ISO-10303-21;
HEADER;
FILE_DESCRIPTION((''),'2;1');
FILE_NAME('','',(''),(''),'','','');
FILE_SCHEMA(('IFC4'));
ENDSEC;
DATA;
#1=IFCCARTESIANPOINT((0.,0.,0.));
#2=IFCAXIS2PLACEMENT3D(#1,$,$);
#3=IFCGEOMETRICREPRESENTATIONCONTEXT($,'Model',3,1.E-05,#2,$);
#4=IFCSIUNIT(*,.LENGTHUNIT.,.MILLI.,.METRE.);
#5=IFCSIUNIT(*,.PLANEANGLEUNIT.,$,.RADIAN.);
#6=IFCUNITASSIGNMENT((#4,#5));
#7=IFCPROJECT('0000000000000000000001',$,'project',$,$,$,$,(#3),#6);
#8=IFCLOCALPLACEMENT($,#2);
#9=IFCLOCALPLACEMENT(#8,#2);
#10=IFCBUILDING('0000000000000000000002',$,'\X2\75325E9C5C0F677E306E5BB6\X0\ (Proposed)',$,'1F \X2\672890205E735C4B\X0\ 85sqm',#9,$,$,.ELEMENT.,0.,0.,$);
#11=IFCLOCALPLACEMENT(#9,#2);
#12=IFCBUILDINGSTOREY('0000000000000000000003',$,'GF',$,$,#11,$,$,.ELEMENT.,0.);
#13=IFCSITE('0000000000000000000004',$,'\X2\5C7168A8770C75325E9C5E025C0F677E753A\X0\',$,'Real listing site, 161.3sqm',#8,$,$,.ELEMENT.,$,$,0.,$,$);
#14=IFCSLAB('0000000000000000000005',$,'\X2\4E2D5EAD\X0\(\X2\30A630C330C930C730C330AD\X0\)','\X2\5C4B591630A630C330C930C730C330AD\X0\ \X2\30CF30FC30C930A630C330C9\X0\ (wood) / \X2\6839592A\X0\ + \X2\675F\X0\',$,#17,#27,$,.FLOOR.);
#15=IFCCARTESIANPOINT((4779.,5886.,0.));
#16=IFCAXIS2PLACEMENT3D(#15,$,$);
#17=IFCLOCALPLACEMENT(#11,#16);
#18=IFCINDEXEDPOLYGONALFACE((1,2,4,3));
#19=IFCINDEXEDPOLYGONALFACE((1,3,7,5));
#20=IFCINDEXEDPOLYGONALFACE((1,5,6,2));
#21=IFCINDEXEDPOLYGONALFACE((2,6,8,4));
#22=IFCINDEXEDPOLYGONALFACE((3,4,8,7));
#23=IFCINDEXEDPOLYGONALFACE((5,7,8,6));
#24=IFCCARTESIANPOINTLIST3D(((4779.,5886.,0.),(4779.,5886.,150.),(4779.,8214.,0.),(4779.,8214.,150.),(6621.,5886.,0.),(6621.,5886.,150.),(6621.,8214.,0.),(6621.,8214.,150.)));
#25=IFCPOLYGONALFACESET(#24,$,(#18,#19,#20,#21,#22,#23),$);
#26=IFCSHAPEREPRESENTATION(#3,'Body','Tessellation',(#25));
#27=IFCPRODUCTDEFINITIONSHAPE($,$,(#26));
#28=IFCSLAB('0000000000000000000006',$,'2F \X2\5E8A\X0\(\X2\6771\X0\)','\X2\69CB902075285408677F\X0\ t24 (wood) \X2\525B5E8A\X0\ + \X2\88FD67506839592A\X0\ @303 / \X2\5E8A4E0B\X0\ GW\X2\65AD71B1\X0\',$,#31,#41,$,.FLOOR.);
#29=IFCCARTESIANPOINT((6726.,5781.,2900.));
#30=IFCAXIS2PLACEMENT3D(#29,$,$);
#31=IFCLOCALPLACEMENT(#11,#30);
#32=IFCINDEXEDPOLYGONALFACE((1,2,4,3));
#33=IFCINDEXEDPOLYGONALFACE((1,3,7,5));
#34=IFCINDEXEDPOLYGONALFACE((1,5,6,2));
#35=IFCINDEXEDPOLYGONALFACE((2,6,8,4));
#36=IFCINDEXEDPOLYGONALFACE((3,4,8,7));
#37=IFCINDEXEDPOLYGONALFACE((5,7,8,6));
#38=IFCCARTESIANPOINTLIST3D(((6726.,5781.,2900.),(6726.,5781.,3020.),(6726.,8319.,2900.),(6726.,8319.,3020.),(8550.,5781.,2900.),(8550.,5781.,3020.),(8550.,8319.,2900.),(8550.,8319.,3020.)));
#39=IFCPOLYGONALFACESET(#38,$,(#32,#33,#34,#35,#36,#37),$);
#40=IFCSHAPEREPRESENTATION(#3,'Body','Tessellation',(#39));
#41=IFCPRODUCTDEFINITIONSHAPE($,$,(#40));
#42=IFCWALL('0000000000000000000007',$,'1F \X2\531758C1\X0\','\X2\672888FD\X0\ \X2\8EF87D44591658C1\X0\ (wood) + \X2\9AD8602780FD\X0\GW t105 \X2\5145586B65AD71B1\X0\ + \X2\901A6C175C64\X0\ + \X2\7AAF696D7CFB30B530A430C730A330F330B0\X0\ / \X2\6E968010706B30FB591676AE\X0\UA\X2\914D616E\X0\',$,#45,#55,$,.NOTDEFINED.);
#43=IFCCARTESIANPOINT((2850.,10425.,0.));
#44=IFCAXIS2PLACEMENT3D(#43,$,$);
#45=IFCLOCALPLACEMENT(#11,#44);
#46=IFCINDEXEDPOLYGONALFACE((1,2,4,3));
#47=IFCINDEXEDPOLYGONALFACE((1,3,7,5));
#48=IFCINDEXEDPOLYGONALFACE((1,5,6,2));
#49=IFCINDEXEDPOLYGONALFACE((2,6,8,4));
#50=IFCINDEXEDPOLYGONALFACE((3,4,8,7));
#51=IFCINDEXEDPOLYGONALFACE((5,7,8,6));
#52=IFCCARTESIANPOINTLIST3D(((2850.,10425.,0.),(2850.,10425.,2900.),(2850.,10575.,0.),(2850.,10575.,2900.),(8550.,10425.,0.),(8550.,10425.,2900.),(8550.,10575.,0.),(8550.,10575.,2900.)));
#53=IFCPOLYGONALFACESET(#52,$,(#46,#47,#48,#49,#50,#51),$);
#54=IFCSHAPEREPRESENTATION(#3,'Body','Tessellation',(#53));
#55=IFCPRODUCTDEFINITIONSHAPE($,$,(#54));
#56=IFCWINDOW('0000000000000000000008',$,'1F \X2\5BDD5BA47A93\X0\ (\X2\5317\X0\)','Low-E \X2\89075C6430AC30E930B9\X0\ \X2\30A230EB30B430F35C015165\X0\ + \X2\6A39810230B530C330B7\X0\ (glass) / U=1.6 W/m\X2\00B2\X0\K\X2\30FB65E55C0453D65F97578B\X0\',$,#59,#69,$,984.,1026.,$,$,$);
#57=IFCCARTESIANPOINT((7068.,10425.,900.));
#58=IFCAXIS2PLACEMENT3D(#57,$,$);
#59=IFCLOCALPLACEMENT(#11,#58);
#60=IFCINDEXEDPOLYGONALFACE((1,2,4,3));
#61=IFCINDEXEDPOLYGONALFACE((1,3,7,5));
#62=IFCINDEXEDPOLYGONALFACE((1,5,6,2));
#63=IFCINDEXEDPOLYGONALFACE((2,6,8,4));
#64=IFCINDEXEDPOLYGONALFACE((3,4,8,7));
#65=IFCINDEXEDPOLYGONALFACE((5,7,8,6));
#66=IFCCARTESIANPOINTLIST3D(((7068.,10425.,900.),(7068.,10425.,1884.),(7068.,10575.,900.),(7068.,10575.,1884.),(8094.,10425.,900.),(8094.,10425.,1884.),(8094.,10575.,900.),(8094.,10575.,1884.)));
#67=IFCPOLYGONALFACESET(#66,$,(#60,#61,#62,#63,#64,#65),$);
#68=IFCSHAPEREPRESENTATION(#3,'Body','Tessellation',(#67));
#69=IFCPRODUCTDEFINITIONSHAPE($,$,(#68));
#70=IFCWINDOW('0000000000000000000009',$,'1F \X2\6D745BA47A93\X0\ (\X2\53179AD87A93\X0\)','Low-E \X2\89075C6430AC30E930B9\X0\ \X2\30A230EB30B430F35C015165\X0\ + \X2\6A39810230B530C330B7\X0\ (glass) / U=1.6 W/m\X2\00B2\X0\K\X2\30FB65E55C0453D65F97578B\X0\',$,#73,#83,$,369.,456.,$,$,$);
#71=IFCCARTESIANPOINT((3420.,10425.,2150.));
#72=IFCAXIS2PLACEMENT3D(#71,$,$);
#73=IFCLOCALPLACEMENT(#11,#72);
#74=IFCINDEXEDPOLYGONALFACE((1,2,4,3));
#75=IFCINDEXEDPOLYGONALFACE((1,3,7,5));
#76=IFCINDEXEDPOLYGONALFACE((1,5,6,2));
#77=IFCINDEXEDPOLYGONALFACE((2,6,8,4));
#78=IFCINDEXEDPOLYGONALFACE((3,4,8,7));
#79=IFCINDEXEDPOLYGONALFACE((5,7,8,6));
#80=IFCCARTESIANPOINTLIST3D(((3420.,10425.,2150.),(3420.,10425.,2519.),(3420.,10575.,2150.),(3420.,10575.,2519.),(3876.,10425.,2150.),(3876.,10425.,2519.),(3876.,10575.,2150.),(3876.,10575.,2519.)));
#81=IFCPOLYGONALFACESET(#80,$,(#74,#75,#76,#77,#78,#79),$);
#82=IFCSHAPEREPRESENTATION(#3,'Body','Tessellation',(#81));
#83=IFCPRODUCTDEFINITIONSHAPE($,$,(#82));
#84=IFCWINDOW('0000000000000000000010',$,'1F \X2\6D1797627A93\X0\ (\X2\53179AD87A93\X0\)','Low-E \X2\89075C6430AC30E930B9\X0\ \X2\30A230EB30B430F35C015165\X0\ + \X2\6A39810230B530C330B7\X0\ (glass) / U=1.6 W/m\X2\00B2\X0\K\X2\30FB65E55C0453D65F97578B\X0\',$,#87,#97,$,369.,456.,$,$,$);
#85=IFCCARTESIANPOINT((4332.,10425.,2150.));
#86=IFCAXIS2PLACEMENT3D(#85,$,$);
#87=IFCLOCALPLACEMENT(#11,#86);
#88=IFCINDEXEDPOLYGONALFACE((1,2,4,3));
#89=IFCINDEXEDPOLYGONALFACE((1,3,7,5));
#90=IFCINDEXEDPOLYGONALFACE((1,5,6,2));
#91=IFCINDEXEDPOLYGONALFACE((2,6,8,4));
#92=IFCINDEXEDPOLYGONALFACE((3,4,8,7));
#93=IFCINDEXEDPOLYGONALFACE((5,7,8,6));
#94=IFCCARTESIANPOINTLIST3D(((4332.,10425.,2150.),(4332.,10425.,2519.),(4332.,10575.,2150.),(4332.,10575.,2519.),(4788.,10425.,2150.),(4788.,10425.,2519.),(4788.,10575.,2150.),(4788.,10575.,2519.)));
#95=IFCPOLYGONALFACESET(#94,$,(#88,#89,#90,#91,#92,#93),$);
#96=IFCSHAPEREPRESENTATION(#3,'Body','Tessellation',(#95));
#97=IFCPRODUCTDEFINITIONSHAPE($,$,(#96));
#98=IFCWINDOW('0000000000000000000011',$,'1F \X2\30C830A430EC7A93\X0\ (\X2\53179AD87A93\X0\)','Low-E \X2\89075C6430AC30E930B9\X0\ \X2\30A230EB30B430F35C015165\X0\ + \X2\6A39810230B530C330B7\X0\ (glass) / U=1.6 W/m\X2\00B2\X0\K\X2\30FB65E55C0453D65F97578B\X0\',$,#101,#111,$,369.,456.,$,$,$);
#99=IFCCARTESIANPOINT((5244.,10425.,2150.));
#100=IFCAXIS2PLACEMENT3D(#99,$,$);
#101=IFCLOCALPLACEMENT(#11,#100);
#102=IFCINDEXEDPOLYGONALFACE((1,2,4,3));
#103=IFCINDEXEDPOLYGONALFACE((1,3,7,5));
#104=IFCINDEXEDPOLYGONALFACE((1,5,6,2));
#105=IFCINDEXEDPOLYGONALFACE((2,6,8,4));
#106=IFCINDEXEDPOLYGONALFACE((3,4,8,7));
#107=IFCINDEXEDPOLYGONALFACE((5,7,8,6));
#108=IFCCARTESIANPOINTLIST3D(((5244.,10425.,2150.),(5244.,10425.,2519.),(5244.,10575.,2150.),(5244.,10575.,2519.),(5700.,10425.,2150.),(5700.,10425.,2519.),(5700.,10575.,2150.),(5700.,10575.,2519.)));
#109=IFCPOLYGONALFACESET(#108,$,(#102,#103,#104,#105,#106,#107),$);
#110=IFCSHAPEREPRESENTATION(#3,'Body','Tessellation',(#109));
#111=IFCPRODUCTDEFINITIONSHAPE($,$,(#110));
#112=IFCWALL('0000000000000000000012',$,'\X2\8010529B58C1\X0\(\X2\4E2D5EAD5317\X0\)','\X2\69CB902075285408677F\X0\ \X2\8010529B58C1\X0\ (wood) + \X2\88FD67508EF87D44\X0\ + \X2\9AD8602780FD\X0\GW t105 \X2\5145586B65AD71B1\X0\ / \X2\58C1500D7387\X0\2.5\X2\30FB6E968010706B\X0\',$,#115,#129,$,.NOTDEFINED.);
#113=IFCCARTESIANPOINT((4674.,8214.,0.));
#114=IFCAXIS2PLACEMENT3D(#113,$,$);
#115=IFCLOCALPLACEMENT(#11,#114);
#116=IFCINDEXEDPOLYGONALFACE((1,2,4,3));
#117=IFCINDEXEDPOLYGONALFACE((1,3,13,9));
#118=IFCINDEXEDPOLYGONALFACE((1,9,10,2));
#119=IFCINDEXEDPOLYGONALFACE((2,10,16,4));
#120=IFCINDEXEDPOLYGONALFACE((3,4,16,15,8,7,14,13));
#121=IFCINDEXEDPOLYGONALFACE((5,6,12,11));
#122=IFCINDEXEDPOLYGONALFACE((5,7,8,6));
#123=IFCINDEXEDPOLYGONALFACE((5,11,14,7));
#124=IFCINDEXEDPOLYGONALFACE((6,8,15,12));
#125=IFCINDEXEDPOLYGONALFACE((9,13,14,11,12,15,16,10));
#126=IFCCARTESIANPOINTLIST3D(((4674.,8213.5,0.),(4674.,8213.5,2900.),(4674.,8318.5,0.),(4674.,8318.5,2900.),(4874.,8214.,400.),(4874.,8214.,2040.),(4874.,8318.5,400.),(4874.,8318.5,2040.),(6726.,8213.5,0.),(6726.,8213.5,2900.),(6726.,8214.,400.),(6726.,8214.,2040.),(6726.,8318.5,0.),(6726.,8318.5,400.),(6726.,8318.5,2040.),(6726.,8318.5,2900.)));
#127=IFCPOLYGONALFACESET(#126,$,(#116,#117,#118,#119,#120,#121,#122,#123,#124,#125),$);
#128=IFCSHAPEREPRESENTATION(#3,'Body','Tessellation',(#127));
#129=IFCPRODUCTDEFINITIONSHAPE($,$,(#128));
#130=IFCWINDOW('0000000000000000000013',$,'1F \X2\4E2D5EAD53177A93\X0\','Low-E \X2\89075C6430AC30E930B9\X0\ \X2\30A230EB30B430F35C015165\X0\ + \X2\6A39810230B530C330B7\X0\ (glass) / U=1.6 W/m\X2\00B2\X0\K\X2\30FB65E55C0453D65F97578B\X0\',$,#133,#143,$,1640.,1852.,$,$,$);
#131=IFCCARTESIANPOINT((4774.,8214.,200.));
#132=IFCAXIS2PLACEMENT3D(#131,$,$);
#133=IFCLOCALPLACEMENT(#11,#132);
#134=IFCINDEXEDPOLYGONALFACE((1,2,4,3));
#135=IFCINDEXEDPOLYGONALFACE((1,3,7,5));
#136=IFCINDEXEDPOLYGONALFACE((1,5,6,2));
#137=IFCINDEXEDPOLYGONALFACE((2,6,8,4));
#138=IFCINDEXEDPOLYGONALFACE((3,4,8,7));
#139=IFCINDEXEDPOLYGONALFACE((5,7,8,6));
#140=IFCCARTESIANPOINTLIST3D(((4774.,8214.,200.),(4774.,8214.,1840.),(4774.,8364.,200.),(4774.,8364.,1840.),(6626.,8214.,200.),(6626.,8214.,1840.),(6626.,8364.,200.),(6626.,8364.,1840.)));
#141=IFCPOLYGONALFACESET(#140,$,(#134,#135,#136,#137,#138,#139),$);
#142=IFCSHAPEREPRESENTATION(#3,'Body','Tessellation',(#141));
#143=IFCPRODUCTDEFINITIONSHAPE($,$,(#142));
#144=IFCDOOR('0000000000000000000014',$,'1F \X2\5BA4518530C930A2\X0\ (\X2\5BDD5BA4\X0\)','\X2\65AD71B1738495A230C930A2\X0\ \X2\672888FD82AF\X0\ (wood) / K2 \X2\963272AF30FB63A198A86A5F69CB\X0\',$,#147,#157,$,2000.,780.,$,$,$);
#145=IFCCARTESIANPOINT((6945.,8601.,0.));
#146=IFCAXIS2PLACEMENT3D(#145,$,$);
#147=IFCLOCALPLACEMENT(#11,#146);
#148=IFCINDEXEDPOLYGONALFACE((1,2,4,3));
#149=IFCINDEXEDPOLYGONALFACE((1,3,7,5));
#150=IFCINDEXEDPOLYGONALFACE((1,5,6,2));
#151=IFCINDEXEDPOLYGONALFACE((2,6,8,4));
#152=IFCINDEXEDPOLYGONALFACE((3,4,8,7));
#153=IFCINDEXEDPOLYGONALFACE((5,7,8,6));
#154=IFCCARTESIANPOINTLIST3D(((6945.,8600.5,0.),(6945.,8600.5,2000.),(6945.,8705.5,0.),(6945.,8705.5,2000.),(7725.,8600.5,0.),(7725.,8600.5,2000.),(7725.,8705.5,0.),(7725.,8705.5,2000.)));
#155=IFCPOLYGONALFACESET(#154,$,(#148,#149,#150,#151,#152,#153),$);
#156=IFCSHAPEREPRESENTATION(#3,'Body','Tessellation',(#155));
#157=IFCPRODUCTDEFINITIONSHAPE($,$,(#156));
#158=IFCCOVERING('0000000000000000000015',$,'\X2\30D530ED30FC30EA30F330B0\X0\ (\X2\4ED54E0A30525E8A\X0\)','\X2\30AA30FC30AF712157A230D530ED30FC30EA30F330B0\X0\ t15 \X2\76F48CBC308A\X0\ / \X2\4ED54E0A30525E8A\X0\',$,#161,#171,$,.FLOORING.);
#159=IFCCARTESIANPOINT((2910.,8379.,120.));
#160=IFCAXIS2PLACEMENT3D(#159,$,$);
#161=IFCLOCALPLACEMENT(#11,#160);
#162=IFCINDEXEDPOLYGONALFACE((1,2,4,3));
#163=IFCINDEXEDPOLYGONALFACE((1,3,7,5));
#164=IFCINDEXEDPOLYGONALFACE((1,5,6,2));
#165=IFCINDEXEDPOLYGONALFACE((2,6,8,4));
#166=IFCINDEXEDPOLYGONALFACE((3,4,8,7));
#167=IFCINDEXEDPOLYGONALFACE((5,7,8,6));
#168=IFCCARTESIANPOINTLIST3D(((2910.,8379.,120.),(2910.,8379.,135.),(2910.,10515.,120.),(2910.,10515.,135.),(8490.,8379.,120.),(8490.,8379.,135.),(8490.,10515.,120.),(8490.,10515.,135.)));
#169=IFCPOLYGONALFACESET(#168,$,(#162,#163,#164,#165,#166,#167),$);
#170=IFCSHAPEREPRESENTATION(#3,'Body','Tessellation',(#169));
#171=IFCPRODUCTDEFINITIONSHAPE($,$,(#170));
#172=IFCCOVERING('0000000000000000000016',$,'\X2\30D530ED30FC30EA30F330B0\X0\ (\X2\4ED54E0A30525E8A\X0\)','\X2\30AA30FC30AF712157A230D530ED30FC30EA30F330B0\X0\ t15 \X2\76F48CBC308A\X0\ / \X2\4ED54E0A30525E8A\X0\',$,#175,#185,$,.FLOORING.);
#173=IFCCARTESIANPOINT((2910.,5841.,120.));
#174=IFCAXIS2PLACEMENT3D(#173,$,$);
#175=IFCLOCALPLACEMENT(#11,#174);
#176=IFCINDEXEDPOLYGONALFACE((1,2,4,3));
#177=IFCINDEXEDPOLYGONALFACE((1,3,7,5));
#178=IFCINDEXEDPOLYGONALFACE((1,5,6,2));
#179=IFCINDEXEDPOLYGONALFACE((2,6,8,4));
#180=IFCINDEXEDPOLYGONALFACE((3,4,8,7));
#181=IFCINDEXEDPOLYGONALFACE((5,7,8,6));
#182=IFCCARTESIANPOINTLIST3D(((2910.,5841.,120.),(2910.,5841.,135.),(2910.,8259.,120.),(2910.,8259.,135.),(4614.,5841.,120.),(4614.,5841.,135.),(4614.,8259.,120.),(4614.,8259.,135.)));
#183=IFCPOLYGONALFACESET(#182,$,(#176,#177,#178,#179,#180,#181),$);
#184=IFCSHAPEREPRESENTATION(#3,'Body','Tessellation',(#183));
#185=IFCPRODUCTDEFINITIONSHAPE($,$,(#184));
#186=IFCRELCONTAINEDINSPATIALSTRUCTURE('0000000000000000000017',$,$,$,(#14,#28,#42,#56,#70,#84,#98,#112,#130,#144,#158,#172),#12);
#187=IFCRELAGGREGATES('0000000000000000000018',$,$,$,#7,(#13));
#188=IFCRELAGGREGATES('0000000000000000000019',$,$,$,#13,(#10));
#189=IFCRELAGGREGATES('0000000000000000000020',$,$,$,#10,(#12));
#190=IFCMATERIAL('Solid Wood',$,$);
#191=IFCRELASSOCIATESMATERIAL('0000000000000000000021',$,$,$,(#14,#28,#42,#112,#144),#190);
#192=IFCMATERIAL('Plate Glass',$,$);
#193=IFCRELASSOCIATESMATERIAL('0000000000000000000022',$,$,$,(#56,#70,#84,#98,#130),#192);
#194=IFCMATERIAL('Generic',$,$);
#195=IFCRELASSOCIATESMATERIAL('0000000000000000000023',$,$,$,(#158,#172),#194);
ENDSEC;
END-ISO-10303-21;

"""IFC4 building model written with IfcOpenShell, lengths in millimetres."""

from ifc_helpers import new_model, si_unit, frame, frame_2d, origin, place, context, project, spatial, rectangle, extrude, material, element, fill, save


model = new_model("IFC4")

# Units and contexts
model_context = context("Model", 3, precision=1e-05, world=origin())
ifc_project = project(units=[si_unit("LENGTHUNIT", "METRE", prefix="MILLI"), si_unit("PLANEANGLEUNIT", "RADIAN")], contexts=[model_context])

# Site, building, storey
site_placement = place(None, origin())
site = spatial("IfcSite", under=ifc_project, at=site_placement, Name="山梨県甲府市小松町", ObjectType="Real listing site, 161.3sqm", CompositionType="ELEMENT", RefElevation=0.0)
building_placement = place(site_placement, origin())
building = spatial("IfcBuilding", under=site, at=building_placement, Name="甲府小松の家 (Proposed)", ObjectType="1F 木造平屋 85sqm", CompositionType="ELEMENT", ElevationOfRefHeight=0.0, ElevationOfTerrain=0.0)
storey_placement = place(building_placement, origin())
storey = spatial("IfcBuildingStorey", under=building, at=storey_placement, Name="GF", CompositionType="ELEMENT", Elevation=0.0)

# Slabs
ifc_material_1 = material(Name="Solid Wood")
slab_1_placement = place(storey_placement, frame((4779.0, 5886.0, 0.0)))
element("IfcSlab", 1, at=slab_1_placement, inside=storey, material=ifc_material_1, Name="中庭(ウッドデッキ)", Description="屋外ウッドデッキ ハードウッド (wood) / 根太 + 束", PredefinedType="FLOOR", context=model_context, shape_type="SweptSolid", body=[
    extrude(rectangle(XDim=1842.0, YDim=2328.0, at=frame_2d((921.0, 1164.0))), frame((4779.0, 5886.0, 0.0)), (0.0, 0.0, 1.0), 150.0),
])
slab_2_placement = place(storey_placement, frame((6726.0, 5781.0, 2900.0)))
element("IfcSlab", 2, at=slab_2_placement, inside=storey, material=ifc_material_1, Name="2F 床(東)", Description="構造用合板 t24 (wood) 剛床 + 製材根太 @303 / 床下 GW断熱", PredefinedType="FLOOR", context=model_context, shape_type="SweptSolid", body=[
    extrude(rectangle(XDim=1824.0, YDim=2538.0, at=frame_2d((912.0, 1269.0))), frame((6726.0, 5781.0, 2900.0)), (0.0, 0.0, 1.0), 120.0),
])

# Wall, openings, windows
wall_1_placement = place(storey_placement, frame((2850.0, 10425.0, 0.0)))
wall_1 = element("IfcWall", 3, at=wall_1_placement, inside=storey, material=ifc_material_1, Name="1F 北壁", Description="木製 軸組外壁 (wood) + 高性能GW t105 充填断熱 + 通気層 + 窯業系サイディング / 準耐火・外皮UA配慮", PredefinedType="NOTDEFINED", context=model_context, shape_type="SweptSolid", body=[
    extrude(rectangle(XDim=5700.0, YDim=150.0, at=frame_2d((2850.0, 75.0))), frame((2850.0, 10425.0, 0.0)), (0.0, 0.0, 1.0), 2900.0),
])
opening_1_placement = place(storey_placement, frame((7068.0, 10425.0, 900.0)))
opening_1 = element("IfcOpeningElement", 4, at=opening_1_placement, cuts=wall_1, PredefinedType="NOTDEFINED", context=model_context, shape_type="SweptSolid", body=[
    extrude(rectangle(XDim=1026.0, YDim=150.0, at=frame_2d((513.0, 75.0))), frame((7068.0, 10425.0, 900.0)), (0.0, 0.0, 1.0), 984.0),
])
opening_2_placement = place(storey_placement, frame((3420.0, 10425.0, 2150.0)))
opening_2 = element("IfcOpeningElement", 5, at=opening_2_placement, cuts=wall_1, PredefinedType="NOTDEFINED", context=model_context, shape_type="SweptSolid", body=[
    extrude(rectangle(XDim=456.0, YDim=150.0, at=frame_2d((228.0, 75.0))), frame((3420.0, 10425.0, 2150.0)), (0.0, 0.0, 1.0), 369.0),
])
opening_3_placement = place(storey_placement, frame((4332.0, 10425.0, 2150.0)))
opening_3 = element("IfcOpeningElement", 6, at=opening_3_placement, cuts=wall_1, PredefinedType="NOTDEFINED", context=model_context, shape_type="SweptSolid", body=[
    extrude(rectangle(XDim=456.0, YDim=150.0, at=frame_2d((228.0, 75.0))), frame((4332.0, 10425.0, 2150.0)), (0.0, 0.0, 1.0), 369.0),
])
opening_4_placement = place(storey_placement, frame((5244.0, 10425.0, 2150.0)))
opening_4 = element("IfcOpeningElement", 7, at=opening_4_placement, cuts=wall_1, PredefinedType="NOTDEFINED", context=model_context, shape_type="SweptSolid", body=[
    extrude(rectangle(XDim=456.0, YDim=150.0, at=frame_2d((228.0, 75.0))), frame((5244.0, 10425.0, 2150.0)), (0.0, 0.0, 1.0), 369.0),
])
ifc_material_2 = material(Name="Plate Glass")
window_1_placement = place(storey_placement, frame((7068.0, 10425.0, 900.0)))
window_1 = element("IfcWindow", 8, at=window_1_placement, inside=storey, material=ifc_material_2, Name="1F 寝室窓 (北)", Description="Low-E 複層ガラス アルゴン封入 + 樹脂サッシ (glass) / U=1.6 W/m²K・日射取得型", OverallHeight=984.0, OverallWidth=1026.0, context=model_context, shape_type="SweptSolid", body=[
    extrude(rectangle(XDim=1026.0, YDim=150.0, at=frame_2d((513.0, 75.0))), frame((7068.0, 10425.0, 900.0)), (0.0, 0.0, 1.0), 984.0),
])
fill(opening_1, window_1)
window_2_placement = place(storey_placement, frame((3420.0, 10425.0, 2150.0)))
window_2 = element("IfcWindow", 9, at=window_2_placement, inside=storey, material=ifc_material_2, Name="1F 浴室窓 (北高窓)", Description="Low-E 複層ガラス アルゴン封入 + 樹脂サッシ (glass) / U=1.6 W/m²K・日射取得型", OverallHeight=369.0, OverallWidth=456.0, context=model_context, shape_type="SweptSolid", body=[
    extrude(rectangle(XDim=456.0, YDim=150.0, at=frame_2d((228.0, 75.0))), frame((3420.0, 10425.0, 2150.0)), (0.0, 0.0, 1.0), 369.0),
])
fill(opening_2, window_2)
window_3_placement = place(storey_placement, frame((4332.0, 10425.0, 2150.0)))
window_3 = element("IfcWindow", 10, at=window_3_placement, inside=storey, material=ifc_material_2, Name="1F 洗面窓 (北高窓)", Description="Low-E 複層ガラス アルゴン封入 + 樹脂サッシ (glass) / U=1.6 W/m²K・日射取得型", OverallHeight=369.0, OverallWidth=456.0, context=model_context, shape_type="SweptSolid", body=[
    extrude(rectangle(XDim=456.0, YDim=150.0, at=frame_2d((228.0, 75.0))), frame((4332.0, 10425.0, 2150.0)), (0.0, 0.0, 1.0), 369.0),
])
fill(opening_3, window_3)
window_4_placement = place(storey_placement, frame((5244.0, 10425.0, 2150.0)))
window_4 = element("IfcWindow", 11, at=window_4_placement, inside=storey, material=ifc_material_2, Name="1F トイレ窓 (北高窓)", Description="Low-E 複層ガラス アルゴン封入 + 樹脂サッシ (glass) / U=1.6 W/m²K・日射取得型", OverallHeight=369.0, OverallWidth=456.0, context=model_context, shape_type="SweptSolid", body=[
    extrude(rectangle(XDim=456.0, YDim=150.0, at=frame_2d((228.0, 75.0))), frame((5244.0, 10425.0, 2150.0)), (0.0, 0.0, 1.0), 369.0),
])
fill(opening_4, window_4)

# Wall, opening, window
wall_2_placement = place(storey_placement, frame((4674.0, 8214.0, 0.0)))
wall_2 = element("IfcWall", 12, at=wall_2_placement, inside=storey, material=ifc_material_1, Name="耐力壁(中庭北)", Description="構造用合板 耐力壁 (wood) + 製材軸組 + 高性能GW t105 充填断熱 / 壁倍率2.5・準耐火", PredefinedType="NOTDEFINED", context=model_context, shape_type="SweptSolid", body=[
    extrude(rectangle(XDim=2052.0, YDim=105.0, at=frame_2d((1026.0, 52.0))), frame((4674.0, 8214.0, 0.0)), (0.0, 0.0, 1.0), 2900.0),
])
opening_5_placement = place(storey_placement, frame((4774.0, 8214.0, 200.0)))
opening_5 = element("IfcOpeningElement", 13, at=opening_5_placement, cuts=wall_2, PredefinedType="NOTDEFINED", context=model_context, shape_type="SweptSolid", body=[
    extrude(rectangle(XDim=1852.0, YDim=150.0, at=frame_2d((926.0, 75.0))), frame((4774.0, 8214.0, 200.0)), (0.0, 0.0, 1.0), 1640.0),
])
window_5_placement = place(storey_placement, frame((4774.0, 8214.0, 200.0)))
window_5 = element("IfcWindow", 14, at=window_5_placement, inside=storey, material=ifc_material_2, Name="1F 中庭北窓", Description="Low-E 複層ガラス アルゴン封入 + 樹脂サッシ (glass) / U=1.6 W/m²K・日射取得型", OverallHeight=1640.0, OverallWidth=1852.0, context=model_context, shape_type="SweptSolid", body=[
    extrude(rectangle(XDim=1852.0, YDim=150.0, at=frame_2d((926.0, 75.0))), frame((4774.0, 8214.0, 200.0)), (0.0, 0.0, 1.0), 1640.0),
])
fill(opening_5, window_5)

# Door
door_1_placement = place(storey_placement, frame((6945.0, 8601.0, 0.0)))
element("IfcDoor", 15, at=door_1_placement, inside=storey, material=ifc_material_1, Name="1F 室内ドア (寝室)", Description="断熱玄関ドア 木製芯 (wood) / K2 防犯・採風機構", OverallHeight=2000.0, OverallWidth=780.0, context=model_context, shape_type="SweptSolid", body=[
    extrude(rectangle(XDim=780.0, YDim=105.0, at=frame_2d((390.0, 52.0))), frame((6945.0, 8601.0, 0.0)), (0.0, 0.0, 1.0), 2000.0),
])

# Coverings
ifc_material_3 = material(Name="Generic")
covering_1_placement = place(storey_placement, frame((2910.0, 8379.0, 120.0)))
element("IfcCovering", 16, at=covering_1_placement, inside=storey, material=ifc_material_3, Name="フローリング (仕上げ床)", Description="オーク無垢フローリング t15 直貼り / 仕上げ床", PredefinedType="FLOORING", context=model_context, shape_type="SweptSolid", body=[
    extrude(rectangle(XDim=5580.0, YDim=2136.0, at=frame_2d((2790.0, 1068.0))), frame((2910.0, 8379.0, 120.0)), (0.0, 0.0, 1.0), 15.0),
])
covering_2_placement = place(storey_placement, frame((2910.0, 5841.0, 120.0)))
element("IfcCovering", 17, at=covering_2_placement, inside=storey, material=ifc_material_3, Name="フローリング (仕上げ床)", Description="オーク無垢フローリング t15 直貼り / 仕上げ床", PredefinedType="FLOORING", context=model_context, shape_type="SweptSolid", body=[
    extrude(rectangle(XDim=1704.0, YDim=2418.0, at=frame_2d((852.0, 1209.0))), frame((2910.0, 5841.0, 120.0)), (0.0, 0.0, 1.0), 15.0),
])

save(model, "model.ifc")
